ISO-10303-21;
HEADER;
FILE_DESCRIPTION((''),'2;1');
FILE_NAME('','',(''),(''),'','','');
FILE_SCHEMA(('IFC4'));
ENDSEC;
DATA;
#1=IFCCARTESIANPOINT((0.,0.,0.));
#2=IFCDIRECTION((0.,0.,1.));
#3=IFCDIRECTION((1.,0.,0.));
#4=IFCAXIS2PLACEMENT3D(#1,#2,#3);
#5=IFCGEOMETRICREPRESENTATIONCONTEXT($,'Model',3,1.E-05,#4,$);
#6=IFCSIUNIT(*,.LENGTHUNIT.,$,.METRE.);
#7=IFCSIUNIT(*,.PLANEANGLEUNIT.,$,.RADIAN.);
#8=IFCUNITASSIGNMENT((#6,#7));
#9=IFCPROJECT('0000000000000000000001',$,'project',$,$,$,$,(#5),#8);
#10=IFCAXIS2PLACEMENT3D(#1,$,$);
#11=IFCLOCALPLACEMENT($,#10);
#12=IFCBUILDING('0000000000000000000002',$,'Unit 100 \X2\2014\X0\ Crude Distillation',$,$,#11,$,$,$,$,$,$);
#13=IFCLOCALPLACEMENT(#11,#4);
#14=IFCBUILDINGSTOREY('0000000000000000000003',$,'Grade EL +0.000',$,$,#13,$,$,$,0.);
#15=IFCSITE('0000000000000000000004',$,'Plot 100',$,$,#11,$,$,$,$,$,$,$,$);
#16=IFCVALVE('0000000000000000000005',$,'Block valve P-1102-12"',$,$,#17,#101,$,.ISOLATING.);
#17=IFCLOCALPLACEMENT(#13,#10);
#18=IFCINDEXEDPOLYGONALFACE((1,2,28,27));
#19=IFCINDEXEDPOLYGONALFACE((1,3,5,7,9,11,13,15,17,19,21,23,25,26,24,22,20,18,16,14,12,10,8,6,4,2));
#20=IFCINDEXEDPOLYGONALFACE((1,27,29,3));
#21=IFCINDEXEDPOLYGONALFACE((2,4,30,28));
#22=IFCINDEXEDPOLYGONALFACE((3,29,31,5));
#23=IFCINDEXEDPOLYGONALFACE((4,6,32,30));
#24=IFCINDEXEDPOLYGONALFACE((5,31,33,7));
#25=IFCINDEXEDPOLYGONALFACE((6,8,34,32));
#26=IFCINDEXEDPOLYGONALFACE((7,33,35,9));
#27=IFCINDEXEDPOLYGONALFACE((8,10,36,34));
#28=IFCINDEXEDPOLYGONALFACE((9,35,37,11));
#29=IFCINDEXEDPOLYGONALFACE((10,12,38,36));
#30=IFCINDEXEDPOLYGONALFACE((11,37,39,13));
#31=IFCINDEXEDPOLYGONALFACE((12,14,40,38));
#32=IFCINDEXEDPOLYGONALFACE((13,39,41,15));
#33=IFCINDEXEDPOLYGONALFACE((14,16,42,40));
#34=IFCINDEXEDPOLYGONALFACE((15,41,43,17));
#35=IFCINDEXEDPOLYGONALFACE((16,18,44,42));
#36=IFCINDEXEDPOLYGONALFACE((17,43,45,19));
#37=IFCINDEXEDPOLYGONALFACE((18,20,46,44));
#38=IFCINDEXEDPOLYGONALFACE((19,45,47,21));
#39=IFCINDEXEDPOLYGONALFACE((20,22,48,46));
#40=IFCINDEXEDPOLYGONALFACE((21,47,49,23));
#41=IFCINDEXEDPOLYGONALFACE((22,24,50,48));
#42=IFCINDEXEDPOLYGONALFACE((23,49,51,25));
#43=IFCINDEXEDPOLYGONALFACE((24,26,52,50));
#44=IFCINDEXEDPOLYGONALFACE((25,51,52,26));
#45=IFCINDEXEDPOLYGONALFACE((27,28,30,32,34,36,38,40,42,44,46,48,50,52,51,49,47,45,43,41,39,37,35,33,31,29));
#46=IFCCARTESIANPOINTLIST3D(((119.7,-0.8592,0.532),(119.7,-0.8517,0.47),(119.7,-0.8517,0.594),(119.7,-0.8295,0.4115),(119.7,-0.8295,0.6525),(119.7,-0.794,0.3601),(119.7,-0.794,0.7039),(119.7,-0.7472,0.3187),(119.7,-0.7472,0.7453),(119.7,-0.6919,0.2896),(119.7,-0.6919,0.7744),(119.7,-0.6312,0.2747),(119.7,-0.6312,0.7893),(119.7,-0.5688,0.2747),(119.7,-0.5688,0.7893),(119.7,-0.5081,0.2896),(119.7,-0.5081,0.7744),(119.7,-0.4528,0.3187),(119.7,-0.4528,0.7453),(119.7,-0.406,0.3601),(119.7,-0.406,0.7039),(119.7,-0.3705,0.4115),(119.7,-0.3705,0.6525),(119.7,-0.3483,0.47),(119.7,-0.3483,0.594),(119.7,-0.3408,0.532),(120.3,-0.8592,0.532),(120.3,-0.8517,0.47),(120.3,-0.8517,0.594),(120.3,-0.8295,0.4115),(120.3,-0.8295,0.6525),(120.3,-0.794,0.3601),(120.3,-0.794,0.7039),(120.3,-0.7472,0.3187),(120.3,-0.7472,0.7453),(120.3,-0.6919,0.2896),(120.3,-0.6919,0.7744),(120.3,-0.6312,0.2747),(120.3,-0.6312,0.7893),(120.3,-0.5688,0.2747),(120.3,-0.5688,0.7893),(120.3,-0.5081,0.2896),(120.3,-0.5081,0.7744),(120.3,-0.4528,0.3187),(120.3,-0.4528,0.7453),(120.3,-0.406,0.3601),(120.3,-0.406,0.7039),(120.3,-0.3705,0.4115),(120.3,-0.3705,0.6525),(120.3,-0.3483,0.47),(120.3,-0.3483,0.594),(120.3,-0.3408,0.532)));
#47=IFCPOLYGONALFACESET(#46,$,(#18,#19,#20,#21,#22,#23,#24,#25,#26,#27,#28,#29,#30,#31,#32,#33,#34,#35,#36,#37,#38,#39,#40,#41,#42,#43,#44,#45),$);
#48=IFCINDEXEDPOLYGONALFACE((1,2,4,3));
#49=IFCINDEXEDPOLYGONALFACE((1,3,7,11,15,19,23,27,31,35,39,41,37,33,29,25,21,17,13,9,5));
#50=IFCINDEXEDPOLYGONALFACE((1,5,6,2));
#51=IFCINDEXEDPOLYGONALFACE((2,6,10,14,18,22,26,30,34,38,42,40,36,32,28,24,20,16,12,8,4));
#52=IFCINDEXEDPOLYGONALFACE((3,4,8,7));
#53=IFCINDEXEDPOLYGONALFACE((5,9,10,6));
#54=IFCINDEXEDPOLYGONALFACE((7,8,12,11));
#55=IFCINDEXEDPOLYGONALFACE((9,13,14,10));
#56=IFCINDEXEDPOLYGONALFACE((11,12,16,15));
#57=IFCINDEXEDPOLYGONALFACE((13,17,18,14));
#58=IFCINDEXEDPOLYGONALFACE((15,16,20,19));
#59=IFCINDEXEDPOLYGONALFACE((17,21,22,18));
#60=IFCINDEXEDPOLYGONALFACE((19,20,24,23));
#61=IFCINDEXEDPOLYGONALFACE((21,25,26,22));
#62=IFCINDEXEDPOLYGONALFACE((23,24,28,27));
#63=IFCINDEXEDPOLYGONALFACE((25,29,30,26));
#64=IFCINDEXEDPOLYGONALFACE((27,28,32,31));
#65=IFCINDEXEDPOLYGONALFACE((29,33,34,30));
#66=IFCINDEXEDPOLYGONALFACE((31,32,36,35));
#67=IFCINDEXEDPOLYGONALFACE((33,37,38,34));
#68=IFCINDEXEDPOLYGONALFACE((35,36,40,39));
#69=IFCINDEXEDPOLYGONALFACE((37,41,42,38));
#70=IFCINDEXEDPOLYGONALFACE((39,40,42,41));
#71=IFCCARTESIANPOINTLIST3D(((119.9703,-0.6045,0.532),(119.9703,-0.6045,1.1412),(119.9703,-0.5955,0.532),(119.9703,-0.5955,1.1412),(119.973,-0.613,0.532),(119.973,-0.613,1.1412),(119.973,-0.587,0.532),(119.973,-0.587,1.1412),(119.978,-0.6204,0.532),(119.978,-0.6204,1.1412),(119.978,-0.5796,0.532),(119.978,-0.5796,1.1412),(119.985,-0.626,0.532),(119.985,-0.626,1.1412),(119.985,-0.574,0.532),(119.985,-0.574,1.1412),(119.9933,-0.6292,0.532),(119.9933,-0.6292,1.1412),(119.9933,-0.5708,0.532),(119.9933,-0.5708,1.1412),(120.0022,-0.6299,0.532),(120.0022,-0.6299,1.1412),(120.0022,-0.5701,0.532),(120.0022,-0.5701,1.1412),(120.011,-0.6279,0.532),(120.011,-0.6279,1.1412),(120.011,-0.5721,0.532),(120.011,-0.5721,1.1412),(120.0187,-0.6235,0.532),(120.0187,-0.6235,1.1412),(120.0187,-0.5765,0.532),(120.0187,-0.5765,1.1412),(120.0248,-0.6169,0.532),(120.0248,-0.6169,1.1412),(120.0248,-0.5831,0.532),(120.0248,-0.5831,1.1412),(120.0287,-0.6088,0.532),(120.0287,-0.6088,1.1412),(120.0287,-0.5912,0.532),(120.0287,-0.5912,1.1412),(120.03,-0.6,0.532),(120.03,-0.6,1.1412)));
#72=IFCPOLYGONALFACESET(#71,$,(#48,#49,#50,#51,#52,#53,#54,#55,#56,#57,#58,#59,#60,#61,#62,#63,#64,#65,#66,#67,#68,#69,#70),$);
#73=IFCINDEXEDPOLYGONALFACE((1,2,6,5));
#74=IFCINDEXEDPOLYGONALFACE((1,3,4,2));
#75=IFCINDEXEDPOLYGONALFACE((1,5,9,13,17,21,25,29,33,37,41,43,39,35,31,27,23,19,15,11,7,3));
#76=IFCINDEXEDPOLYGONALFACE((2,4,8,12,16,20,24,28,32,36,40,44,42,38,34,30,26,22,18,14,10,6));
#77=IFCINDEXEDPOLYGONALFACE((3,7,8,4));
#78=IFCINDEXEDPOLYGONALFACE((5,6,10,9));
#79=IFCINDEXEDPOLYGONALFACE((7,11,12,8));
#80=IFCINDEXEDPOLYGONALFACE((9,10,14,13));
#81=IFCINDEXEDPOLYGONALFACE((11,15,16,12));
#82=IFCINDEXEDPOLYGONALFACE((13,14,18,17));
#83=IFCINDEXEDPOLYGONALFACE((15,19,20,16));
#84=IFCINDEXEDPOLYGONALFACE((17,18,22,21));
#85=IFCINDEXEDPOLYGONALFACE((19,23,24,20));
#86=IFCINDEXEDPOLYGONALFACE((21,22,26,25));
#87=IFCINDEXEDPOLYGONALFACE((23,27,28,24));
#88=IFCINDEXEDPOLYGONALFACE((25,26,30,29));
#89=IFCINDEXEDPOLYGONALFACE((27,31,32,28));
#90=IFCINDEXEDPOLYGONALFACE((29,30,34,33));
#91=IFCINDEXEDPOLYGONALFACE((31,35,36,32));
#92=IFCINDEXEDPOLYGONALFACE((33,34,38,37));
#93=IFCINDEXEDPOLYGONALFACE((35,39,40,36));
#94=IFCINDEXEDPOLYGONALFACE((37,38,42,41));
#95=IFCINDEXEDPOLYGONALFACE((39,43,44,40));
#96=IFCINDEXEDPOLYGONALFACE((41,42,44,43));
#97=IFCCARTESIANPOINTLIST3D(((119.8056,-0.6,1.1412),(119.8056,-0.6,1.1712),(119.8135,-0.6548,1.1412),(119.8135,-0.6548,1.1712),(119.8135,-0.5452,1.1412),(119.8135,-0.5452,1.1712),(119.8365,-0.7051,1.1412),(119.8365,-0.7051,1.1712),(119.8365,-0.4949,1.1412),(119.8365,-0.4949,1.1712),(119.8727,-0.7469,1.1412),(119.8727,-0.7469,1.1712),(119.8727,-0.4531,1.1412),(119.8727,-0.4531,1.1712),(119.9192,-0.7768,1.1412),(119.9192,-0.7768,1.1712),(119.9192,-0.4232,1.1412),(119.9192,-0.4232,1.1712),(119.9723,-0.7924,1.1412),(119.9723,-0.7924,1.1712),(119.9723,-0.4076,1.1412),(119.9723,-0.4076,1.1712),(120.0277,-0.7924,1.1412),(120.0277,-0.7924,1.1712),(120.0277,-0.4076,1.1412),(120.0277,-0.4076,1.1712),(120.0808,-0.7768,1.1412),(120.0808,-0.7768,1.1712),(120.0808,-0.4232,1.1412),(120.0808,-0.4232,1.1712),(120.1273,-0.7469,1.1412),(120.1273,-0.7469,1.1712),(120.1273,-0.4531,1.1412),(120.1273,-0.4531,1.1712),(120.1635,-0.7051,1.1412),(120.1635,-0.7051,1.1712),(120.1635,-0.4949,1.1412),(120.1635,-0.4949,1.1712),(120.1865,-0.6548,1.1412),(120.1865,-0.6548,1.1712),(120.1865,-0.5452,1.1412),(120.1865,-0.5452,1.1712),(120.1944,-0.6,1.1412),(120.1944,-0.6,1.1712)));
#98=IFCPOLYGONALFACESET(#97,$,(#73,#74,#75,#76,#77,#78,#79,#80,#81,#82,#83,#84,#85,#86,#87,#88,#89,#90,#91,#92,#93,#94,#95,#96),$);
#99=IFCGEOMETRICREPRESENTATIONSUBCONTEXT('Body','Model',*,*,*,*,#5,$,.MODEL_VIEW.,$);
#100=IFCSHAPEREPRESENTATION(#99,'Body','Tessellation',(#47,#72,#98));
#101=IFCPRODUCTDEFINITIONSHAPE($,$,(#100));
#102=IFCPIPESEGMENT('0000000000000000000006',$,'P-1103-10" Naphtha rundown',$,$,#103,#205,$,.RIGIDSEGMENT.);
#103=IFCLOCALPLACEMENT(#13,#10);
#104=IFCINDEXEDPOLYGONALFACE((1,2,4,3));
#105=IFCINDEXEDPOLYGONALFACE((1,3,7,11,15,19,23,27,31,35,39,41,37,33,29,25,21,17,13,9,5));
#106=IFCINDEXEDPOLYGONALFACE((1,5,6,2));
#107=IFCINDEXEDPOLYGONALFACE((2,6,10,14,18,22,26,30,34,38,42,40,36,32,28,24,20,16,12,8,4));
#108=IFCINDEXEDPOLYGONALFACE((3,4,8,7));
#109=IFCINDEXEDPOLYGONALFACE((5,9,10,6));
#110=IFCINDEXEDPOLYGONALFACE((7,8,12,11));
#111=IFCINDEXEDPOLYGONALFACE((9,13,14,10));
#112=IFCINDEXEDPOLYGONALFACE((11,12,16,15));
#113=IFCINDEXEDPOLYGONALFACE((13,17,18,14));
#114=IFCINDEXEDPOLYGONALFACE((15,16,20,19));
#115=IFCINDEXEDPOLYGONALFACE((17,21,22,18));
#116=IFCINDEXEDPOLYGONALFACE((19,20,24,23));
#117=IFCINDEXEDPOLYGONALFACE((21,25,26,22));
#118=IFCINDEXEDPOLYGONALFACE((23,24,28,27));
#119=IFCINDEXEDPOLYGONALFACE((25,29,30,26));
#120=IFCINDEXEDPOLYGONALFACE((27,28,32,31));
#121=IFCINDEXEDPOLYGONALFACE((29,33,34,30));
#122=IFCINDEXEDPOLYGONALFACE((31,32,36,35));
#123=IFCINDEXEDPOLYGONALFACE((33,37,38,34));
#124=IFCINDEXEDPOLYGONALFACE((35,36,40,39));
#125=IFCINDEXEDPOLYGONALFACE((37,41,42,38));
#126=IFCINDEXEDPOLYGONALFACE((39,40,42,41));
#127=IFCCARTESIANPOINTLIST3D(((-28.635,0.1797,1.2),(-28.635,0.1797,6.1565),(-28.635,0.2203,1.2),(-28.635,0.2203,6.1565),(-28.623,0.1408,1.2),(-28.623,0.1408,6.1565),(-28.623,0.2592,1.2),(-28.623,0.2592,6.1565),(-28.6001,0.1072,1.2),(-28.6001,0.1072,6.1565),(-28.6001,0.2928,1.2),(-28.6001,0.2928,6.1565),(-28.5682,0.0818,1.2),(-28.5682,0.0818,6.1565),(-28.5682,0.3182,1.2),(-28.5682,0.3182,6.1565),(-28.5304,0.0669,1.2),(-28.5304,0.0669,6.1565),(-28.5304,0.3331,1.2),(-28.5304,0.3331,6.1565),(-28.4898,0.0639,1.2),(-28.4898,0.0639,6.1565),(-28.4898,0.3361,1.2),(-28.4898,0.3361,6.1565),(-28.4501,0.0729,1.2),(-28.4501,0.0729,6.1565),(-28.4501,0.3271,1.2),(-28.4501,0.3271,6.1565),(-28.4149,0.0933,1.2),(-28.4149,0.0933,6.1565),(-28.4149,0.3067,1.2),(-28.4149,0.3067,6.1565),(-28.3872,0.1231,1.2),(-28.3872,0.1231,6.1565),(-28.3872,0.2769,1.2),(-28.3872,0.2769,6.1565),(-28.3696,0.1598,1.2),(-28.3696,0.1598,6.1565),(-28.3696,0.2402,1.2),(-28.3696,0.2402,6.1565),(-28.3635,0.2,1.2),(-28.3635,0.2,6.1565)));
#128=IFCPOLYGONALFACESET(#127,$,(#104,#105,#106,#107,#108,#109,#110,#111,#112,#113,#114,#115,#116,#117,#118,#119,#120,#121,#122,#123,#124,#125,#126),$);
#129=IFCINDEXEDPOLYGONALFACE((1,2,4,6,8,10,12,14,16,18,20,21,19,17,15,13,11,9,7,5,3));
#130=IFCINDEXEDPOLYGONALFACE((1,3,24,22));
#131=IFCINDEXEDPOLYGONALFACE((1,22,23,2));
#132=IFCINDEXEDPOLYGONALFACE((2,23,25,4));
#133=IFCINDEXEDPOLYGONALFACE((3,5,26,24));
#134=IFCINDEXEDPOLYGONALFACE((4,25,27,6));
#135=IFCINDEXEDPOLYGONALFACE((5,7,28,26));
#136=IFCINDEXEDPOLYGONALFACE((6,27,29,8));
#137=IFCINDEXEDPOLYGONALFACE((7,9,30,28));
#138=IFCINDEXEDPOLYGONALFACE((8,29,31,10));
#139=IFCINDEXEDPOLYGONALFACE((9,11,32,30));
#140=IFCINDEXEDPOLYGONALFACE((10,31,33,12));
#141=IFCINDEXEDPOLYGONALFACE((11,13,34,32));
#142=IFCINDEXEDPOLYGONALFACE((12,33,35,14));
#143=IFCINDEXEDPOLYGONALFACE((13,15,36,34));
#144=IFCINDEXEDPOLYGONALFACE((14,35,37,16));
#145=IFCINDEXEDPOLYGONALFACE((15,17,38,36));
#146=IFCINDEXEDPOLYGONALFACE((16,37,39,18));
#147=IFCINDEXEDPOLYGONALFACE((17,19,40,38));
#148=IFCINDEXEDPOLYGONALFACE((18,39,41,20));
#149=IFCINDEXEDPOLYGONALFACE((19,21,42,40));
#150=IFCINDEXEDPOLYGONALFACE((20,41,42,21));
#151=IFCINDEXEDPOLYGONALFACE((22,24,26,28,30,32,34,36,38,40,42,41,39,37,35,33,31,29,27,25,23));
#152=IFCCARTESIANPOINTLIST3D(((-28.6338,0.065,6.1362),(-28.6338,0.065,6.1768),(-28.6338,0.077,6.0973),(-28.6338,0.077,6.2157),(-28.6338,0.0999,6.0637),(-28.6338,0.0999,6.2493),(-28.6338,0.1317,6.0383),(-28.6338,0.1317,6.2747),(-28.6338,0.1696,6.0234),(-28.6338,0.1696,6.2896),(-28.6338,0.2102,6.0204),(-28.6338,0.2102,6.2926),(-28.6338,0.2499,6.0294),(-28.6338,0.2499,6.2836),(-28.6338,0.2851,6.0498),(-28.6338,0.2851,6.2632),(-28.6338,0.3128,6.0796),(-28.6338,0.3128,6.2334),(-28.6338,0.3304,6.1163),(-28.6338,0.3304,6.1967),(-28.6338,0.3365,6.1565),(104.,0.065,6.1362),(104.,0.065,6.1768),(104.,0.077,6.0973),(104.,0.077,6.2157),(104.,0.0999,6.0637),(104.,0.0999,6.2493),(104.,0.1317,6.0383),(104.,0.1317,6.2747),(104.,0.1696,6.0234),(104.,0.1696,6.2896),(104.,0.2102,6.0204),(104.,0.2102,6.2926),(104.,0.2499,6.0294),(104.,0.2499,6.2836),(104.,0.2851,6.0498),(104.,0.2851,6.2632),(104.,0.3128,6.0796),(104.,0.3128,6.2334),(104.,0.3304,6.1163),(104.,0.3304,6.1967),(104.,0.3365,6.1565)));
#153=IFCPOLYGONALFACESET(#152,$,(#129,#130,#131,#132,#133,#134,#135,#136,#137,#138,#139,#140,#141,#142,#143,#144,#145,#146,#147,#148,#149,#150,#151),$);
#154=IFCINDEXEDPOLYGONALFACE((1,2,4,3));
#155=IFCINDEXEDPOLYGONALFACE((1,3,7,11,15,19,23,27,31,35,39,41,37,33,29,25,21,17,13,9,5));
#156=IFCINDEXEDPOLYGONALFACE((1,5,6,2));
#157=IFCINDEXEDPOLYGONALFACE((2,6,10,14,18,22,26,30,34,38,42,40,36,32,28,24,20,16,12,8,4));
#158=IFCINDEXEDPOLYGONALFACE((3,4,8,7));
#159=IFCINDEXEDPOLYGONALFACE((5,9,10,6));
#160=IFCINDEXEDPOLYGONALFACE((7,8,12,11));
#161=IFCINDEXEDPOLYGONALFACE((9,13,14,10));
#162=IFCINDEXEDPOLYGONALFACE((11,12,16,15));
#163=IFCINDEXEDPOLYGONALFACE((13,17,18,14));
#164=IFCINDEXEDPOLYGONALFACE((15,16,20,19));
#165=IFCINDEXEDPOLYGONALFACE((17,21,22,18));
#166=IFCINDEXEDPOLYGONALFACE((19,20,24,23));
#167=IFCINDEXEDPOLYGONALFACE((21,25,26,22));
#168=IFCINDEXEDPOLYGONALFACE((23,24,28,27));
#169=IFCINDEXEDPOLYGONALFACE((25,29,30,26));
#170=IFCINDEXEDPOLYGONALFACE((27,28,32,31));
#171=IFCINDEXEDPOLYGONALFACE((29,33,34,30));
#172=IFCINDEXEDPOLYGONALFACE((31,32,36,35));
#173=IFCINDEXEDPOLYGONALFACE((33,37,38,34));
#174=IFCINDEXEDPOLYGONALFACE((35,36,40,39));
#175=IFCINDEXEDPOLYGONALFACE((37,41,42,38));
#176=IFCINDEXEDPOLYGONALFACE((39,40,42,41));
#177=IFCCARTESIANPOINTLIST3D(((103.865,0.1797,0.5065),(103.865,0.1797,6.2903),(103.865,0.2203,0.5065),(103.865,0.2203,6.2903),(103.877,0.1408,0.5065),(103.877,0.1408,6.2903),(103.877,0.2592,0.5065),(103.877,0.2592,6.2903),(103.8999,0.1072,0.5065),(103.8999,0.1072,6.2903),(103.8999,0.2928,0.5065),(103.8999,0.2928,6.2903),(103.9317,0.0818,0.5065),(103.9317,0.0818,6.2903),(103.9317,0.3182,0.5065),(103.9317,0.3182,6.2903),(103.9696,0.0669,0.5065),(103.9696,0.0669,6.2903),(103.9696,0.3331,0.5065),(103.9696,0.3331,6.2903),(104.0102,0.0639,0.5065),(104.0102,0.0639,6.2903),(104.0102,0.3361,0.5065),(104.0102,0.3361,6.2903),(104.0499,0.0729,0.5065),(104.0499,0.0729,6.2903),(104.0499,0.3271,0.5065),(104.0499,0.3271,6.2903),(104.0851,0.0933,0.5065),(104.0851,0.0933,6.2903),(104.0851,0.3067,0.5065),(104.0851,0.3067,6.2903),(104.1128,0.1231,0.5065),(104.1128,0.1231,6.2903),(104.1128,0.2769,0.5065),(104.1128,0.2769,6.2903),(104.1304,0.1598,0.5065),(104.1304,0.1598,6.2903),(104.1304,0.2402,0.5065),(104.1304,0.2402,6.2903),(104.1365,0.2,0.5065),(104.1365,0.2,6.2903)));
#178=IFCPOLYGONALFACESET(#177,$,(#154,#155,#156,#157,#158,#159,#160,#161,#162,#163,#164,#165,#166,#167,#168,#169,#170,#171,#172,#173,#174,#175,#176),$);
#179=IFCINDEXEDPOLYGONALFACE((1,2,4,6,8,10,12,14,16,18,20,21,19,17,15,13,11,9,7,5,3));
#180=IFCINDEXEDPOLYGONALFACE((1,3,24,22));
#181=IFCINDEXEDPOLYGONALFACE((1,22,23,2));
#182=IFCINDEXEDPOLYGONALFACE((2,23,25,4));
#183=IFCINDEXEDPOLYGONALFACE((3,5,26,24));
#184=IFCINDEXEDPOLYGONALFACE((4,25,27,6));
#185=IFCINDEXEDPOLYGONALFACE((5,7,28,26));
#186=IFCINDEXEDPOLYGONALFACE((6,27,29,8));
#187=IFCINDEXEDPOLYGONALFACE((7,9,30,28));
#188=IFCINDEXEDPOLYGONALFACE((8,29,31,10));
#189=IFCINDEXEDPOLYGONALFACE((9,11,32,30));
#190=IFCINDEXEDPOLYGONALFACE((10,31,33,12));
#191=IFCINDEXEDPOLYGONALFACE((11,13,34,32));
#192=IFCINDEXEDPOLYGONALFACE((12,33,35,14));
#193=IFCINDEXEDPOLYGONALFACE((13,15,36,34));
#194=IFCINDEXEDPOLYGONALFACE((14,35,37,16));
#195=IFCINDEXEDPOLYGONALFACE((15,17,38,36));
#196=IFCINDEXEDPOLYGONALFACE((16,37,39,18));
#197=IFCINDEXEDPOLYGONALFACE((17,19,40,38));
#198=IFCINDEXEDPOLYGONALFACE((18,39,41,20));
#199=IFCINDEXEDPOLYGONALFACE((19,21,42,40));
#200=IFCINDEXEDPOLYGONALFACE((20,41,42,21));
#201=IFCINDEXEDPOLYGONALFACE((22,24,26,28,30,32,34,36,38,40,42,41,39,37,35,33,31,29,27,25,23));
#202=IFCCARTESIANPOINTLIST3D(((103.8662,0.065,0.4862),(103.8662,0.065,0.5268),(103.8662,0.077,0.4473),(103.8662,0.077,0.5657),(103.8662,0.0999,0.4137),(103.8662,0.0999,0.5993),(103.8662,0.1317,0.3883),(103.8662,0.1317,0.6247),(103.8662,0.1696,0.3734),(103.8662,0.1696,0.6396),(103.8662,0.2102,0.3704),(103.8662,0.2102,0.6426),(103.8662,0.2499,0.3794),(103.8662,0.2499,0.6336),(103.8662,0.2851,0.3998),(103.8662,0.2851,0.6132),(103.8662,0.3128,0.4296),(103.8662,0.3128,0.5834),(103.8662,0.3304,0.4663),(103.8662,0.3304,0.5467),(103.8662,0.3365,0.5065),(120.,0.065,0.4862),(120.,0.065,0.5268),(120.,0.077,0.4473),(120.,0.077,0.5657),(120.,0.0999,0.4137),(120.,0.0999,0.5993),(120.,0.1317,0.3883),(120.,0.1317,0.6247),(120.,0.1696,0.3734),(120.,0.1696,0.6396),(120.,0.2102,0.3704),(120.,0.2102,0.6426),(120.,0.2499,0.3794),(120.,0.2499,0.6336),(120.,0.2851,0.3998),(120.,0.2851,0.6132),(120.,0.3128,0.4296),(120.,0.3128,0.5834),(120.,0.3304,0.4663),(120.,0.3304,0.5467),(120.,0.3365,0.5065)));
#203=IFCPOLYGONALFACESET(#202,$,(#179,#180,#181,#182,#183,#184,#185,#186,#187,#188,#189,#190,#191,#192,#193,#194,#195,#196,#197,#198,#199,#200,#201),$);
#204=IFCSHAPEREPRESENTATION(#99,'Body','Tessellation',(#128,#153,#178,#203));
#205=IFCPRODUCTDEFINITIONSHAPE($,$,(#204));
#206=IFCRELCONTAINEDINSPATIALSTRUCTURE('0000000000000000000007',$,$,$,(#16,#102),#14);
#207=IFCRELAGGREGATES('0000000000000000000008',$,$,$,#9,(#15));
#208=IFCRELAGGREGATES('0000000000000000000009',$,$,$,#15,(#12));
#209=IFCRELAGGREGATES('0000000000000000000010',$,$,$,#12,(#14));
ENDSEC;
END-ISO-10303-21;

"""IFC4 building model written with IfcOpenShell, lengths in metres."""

from ifc_helpers import new_model, si_unit, frame, origin, origin_with_axes, origin_2d, place, context, subcontext, project, spatial, circle, extrude, element, save


model = new_model("IFC4")

# Units and contexts
model_context = context("Model", 3, precision=1e-05, world=origin_with_axes())
body_context = subcontext(model_context, "Body", "Model", "MODEL_VIEW")
ifc_project = project(units=[si_unit("LENGTHUNIT", "METRE"), si_unit("PLANEANGLEUNIT", "RADIAN")], contexts=[model_context])

# Site, building, storey
placement = place(None, origin())
site = spatial("IfcSite", under=ifc_project, at=placement, Name="Plot 100")
building = spatial("IfcBuilding", under=site, at=placement, Name="Unit 100 — Crude Distillation")
storey_placement = place(placement, origin_with_axes())
storey = spatial("IfcBuildingStorey", under=building, at=storey_placement, Name="Grade EL +0.000", Elevation=0.0)

# Valve
valve_1_placement = place(storey_placement, origin_with_axes())
element("IfcValve", 1, at=valve_1_placement, inside=storey, Name="Block valve P-1102-12\"", PredefinedType="ISOLATING", context=body_context, shape_type="SweptSolid", body=[
    extrude(circle(Radius=0.2592, at=origin_2d()), frame((119.7, -0.6, 0.532), z_axis=(1.0, 0.0, 0.0), x_axis=(0.0, 1.0, 0.0)), (0.0, 0.0, 1.0), 0.6),
    extrude(circle(Radius=0.03, at=origin_2d()), frame((120.0, -0.6, 0.532), z_axis=(0.0, 0.0, 1.0), x_axis=(1.0, 0.0, 0.0)), (0.0, 0.0, 1.0), 0.6092),
    extrude(circle(Radius=0.1944, at=origin_2d()), frame((120.0, -0.6, 1.1412), z_axis=(0.0, 0.0, 1.0), x_axis=(1.0, 0.0, 0.0)), (0.0, 0.0, 1.0), 0.03),
])

# Pipe segment
pipe_segment_1_placement = place(storey_placement, origin_with_axes())
element("IfcPipeSegment", 2, at=pipe_segment_1_placement, inside=storey, Name="P-1103-10\" Naphtha rundown", PredefinedType="RIGIDSEGMENT", context=body_context, shape_type="SweptSolid", body=[
    extrude(circle(Radius=0.1365, at=origin_2d()), frame((-28.5, 0.2, 1.2), z_axis=(0.0, 0.0, 1.0), x_axis=(1.0, 0.0, 0.0)), (0.0, 0.0, 1.0), 4.9565),
    extrude(circle(Radius=0.1365, at=origin_2d()), frame((-28.6338, 0.2, 6.1565), z_axis=(1.0, 0.0, 0.0), x_axis=(0.0, 1.0, 0.0)), (0.0, 0.0, 1.0), 132.6338),
    extrude(circle(Radius=0.1365, at=origin_2d()), frame((104.0, 0.2, 6.2903), z_axis=(0.0, 0.0, -1.0), x_axis=(1.0, 0.0, 0.0)), (0.0, 0.0, 1.0), 5.7838),
    extrude(circle(Radius=0.1365, at=origin_2d()), frame((103.8662, 0.2, 0.5065), z_axis=(1.0, 0.0, 0.0), x_axis=(0.0, 1.0, 0.0)), (0.0, 0.0, 1.0), 16.1338),
])

save(model, "model.ifc")
